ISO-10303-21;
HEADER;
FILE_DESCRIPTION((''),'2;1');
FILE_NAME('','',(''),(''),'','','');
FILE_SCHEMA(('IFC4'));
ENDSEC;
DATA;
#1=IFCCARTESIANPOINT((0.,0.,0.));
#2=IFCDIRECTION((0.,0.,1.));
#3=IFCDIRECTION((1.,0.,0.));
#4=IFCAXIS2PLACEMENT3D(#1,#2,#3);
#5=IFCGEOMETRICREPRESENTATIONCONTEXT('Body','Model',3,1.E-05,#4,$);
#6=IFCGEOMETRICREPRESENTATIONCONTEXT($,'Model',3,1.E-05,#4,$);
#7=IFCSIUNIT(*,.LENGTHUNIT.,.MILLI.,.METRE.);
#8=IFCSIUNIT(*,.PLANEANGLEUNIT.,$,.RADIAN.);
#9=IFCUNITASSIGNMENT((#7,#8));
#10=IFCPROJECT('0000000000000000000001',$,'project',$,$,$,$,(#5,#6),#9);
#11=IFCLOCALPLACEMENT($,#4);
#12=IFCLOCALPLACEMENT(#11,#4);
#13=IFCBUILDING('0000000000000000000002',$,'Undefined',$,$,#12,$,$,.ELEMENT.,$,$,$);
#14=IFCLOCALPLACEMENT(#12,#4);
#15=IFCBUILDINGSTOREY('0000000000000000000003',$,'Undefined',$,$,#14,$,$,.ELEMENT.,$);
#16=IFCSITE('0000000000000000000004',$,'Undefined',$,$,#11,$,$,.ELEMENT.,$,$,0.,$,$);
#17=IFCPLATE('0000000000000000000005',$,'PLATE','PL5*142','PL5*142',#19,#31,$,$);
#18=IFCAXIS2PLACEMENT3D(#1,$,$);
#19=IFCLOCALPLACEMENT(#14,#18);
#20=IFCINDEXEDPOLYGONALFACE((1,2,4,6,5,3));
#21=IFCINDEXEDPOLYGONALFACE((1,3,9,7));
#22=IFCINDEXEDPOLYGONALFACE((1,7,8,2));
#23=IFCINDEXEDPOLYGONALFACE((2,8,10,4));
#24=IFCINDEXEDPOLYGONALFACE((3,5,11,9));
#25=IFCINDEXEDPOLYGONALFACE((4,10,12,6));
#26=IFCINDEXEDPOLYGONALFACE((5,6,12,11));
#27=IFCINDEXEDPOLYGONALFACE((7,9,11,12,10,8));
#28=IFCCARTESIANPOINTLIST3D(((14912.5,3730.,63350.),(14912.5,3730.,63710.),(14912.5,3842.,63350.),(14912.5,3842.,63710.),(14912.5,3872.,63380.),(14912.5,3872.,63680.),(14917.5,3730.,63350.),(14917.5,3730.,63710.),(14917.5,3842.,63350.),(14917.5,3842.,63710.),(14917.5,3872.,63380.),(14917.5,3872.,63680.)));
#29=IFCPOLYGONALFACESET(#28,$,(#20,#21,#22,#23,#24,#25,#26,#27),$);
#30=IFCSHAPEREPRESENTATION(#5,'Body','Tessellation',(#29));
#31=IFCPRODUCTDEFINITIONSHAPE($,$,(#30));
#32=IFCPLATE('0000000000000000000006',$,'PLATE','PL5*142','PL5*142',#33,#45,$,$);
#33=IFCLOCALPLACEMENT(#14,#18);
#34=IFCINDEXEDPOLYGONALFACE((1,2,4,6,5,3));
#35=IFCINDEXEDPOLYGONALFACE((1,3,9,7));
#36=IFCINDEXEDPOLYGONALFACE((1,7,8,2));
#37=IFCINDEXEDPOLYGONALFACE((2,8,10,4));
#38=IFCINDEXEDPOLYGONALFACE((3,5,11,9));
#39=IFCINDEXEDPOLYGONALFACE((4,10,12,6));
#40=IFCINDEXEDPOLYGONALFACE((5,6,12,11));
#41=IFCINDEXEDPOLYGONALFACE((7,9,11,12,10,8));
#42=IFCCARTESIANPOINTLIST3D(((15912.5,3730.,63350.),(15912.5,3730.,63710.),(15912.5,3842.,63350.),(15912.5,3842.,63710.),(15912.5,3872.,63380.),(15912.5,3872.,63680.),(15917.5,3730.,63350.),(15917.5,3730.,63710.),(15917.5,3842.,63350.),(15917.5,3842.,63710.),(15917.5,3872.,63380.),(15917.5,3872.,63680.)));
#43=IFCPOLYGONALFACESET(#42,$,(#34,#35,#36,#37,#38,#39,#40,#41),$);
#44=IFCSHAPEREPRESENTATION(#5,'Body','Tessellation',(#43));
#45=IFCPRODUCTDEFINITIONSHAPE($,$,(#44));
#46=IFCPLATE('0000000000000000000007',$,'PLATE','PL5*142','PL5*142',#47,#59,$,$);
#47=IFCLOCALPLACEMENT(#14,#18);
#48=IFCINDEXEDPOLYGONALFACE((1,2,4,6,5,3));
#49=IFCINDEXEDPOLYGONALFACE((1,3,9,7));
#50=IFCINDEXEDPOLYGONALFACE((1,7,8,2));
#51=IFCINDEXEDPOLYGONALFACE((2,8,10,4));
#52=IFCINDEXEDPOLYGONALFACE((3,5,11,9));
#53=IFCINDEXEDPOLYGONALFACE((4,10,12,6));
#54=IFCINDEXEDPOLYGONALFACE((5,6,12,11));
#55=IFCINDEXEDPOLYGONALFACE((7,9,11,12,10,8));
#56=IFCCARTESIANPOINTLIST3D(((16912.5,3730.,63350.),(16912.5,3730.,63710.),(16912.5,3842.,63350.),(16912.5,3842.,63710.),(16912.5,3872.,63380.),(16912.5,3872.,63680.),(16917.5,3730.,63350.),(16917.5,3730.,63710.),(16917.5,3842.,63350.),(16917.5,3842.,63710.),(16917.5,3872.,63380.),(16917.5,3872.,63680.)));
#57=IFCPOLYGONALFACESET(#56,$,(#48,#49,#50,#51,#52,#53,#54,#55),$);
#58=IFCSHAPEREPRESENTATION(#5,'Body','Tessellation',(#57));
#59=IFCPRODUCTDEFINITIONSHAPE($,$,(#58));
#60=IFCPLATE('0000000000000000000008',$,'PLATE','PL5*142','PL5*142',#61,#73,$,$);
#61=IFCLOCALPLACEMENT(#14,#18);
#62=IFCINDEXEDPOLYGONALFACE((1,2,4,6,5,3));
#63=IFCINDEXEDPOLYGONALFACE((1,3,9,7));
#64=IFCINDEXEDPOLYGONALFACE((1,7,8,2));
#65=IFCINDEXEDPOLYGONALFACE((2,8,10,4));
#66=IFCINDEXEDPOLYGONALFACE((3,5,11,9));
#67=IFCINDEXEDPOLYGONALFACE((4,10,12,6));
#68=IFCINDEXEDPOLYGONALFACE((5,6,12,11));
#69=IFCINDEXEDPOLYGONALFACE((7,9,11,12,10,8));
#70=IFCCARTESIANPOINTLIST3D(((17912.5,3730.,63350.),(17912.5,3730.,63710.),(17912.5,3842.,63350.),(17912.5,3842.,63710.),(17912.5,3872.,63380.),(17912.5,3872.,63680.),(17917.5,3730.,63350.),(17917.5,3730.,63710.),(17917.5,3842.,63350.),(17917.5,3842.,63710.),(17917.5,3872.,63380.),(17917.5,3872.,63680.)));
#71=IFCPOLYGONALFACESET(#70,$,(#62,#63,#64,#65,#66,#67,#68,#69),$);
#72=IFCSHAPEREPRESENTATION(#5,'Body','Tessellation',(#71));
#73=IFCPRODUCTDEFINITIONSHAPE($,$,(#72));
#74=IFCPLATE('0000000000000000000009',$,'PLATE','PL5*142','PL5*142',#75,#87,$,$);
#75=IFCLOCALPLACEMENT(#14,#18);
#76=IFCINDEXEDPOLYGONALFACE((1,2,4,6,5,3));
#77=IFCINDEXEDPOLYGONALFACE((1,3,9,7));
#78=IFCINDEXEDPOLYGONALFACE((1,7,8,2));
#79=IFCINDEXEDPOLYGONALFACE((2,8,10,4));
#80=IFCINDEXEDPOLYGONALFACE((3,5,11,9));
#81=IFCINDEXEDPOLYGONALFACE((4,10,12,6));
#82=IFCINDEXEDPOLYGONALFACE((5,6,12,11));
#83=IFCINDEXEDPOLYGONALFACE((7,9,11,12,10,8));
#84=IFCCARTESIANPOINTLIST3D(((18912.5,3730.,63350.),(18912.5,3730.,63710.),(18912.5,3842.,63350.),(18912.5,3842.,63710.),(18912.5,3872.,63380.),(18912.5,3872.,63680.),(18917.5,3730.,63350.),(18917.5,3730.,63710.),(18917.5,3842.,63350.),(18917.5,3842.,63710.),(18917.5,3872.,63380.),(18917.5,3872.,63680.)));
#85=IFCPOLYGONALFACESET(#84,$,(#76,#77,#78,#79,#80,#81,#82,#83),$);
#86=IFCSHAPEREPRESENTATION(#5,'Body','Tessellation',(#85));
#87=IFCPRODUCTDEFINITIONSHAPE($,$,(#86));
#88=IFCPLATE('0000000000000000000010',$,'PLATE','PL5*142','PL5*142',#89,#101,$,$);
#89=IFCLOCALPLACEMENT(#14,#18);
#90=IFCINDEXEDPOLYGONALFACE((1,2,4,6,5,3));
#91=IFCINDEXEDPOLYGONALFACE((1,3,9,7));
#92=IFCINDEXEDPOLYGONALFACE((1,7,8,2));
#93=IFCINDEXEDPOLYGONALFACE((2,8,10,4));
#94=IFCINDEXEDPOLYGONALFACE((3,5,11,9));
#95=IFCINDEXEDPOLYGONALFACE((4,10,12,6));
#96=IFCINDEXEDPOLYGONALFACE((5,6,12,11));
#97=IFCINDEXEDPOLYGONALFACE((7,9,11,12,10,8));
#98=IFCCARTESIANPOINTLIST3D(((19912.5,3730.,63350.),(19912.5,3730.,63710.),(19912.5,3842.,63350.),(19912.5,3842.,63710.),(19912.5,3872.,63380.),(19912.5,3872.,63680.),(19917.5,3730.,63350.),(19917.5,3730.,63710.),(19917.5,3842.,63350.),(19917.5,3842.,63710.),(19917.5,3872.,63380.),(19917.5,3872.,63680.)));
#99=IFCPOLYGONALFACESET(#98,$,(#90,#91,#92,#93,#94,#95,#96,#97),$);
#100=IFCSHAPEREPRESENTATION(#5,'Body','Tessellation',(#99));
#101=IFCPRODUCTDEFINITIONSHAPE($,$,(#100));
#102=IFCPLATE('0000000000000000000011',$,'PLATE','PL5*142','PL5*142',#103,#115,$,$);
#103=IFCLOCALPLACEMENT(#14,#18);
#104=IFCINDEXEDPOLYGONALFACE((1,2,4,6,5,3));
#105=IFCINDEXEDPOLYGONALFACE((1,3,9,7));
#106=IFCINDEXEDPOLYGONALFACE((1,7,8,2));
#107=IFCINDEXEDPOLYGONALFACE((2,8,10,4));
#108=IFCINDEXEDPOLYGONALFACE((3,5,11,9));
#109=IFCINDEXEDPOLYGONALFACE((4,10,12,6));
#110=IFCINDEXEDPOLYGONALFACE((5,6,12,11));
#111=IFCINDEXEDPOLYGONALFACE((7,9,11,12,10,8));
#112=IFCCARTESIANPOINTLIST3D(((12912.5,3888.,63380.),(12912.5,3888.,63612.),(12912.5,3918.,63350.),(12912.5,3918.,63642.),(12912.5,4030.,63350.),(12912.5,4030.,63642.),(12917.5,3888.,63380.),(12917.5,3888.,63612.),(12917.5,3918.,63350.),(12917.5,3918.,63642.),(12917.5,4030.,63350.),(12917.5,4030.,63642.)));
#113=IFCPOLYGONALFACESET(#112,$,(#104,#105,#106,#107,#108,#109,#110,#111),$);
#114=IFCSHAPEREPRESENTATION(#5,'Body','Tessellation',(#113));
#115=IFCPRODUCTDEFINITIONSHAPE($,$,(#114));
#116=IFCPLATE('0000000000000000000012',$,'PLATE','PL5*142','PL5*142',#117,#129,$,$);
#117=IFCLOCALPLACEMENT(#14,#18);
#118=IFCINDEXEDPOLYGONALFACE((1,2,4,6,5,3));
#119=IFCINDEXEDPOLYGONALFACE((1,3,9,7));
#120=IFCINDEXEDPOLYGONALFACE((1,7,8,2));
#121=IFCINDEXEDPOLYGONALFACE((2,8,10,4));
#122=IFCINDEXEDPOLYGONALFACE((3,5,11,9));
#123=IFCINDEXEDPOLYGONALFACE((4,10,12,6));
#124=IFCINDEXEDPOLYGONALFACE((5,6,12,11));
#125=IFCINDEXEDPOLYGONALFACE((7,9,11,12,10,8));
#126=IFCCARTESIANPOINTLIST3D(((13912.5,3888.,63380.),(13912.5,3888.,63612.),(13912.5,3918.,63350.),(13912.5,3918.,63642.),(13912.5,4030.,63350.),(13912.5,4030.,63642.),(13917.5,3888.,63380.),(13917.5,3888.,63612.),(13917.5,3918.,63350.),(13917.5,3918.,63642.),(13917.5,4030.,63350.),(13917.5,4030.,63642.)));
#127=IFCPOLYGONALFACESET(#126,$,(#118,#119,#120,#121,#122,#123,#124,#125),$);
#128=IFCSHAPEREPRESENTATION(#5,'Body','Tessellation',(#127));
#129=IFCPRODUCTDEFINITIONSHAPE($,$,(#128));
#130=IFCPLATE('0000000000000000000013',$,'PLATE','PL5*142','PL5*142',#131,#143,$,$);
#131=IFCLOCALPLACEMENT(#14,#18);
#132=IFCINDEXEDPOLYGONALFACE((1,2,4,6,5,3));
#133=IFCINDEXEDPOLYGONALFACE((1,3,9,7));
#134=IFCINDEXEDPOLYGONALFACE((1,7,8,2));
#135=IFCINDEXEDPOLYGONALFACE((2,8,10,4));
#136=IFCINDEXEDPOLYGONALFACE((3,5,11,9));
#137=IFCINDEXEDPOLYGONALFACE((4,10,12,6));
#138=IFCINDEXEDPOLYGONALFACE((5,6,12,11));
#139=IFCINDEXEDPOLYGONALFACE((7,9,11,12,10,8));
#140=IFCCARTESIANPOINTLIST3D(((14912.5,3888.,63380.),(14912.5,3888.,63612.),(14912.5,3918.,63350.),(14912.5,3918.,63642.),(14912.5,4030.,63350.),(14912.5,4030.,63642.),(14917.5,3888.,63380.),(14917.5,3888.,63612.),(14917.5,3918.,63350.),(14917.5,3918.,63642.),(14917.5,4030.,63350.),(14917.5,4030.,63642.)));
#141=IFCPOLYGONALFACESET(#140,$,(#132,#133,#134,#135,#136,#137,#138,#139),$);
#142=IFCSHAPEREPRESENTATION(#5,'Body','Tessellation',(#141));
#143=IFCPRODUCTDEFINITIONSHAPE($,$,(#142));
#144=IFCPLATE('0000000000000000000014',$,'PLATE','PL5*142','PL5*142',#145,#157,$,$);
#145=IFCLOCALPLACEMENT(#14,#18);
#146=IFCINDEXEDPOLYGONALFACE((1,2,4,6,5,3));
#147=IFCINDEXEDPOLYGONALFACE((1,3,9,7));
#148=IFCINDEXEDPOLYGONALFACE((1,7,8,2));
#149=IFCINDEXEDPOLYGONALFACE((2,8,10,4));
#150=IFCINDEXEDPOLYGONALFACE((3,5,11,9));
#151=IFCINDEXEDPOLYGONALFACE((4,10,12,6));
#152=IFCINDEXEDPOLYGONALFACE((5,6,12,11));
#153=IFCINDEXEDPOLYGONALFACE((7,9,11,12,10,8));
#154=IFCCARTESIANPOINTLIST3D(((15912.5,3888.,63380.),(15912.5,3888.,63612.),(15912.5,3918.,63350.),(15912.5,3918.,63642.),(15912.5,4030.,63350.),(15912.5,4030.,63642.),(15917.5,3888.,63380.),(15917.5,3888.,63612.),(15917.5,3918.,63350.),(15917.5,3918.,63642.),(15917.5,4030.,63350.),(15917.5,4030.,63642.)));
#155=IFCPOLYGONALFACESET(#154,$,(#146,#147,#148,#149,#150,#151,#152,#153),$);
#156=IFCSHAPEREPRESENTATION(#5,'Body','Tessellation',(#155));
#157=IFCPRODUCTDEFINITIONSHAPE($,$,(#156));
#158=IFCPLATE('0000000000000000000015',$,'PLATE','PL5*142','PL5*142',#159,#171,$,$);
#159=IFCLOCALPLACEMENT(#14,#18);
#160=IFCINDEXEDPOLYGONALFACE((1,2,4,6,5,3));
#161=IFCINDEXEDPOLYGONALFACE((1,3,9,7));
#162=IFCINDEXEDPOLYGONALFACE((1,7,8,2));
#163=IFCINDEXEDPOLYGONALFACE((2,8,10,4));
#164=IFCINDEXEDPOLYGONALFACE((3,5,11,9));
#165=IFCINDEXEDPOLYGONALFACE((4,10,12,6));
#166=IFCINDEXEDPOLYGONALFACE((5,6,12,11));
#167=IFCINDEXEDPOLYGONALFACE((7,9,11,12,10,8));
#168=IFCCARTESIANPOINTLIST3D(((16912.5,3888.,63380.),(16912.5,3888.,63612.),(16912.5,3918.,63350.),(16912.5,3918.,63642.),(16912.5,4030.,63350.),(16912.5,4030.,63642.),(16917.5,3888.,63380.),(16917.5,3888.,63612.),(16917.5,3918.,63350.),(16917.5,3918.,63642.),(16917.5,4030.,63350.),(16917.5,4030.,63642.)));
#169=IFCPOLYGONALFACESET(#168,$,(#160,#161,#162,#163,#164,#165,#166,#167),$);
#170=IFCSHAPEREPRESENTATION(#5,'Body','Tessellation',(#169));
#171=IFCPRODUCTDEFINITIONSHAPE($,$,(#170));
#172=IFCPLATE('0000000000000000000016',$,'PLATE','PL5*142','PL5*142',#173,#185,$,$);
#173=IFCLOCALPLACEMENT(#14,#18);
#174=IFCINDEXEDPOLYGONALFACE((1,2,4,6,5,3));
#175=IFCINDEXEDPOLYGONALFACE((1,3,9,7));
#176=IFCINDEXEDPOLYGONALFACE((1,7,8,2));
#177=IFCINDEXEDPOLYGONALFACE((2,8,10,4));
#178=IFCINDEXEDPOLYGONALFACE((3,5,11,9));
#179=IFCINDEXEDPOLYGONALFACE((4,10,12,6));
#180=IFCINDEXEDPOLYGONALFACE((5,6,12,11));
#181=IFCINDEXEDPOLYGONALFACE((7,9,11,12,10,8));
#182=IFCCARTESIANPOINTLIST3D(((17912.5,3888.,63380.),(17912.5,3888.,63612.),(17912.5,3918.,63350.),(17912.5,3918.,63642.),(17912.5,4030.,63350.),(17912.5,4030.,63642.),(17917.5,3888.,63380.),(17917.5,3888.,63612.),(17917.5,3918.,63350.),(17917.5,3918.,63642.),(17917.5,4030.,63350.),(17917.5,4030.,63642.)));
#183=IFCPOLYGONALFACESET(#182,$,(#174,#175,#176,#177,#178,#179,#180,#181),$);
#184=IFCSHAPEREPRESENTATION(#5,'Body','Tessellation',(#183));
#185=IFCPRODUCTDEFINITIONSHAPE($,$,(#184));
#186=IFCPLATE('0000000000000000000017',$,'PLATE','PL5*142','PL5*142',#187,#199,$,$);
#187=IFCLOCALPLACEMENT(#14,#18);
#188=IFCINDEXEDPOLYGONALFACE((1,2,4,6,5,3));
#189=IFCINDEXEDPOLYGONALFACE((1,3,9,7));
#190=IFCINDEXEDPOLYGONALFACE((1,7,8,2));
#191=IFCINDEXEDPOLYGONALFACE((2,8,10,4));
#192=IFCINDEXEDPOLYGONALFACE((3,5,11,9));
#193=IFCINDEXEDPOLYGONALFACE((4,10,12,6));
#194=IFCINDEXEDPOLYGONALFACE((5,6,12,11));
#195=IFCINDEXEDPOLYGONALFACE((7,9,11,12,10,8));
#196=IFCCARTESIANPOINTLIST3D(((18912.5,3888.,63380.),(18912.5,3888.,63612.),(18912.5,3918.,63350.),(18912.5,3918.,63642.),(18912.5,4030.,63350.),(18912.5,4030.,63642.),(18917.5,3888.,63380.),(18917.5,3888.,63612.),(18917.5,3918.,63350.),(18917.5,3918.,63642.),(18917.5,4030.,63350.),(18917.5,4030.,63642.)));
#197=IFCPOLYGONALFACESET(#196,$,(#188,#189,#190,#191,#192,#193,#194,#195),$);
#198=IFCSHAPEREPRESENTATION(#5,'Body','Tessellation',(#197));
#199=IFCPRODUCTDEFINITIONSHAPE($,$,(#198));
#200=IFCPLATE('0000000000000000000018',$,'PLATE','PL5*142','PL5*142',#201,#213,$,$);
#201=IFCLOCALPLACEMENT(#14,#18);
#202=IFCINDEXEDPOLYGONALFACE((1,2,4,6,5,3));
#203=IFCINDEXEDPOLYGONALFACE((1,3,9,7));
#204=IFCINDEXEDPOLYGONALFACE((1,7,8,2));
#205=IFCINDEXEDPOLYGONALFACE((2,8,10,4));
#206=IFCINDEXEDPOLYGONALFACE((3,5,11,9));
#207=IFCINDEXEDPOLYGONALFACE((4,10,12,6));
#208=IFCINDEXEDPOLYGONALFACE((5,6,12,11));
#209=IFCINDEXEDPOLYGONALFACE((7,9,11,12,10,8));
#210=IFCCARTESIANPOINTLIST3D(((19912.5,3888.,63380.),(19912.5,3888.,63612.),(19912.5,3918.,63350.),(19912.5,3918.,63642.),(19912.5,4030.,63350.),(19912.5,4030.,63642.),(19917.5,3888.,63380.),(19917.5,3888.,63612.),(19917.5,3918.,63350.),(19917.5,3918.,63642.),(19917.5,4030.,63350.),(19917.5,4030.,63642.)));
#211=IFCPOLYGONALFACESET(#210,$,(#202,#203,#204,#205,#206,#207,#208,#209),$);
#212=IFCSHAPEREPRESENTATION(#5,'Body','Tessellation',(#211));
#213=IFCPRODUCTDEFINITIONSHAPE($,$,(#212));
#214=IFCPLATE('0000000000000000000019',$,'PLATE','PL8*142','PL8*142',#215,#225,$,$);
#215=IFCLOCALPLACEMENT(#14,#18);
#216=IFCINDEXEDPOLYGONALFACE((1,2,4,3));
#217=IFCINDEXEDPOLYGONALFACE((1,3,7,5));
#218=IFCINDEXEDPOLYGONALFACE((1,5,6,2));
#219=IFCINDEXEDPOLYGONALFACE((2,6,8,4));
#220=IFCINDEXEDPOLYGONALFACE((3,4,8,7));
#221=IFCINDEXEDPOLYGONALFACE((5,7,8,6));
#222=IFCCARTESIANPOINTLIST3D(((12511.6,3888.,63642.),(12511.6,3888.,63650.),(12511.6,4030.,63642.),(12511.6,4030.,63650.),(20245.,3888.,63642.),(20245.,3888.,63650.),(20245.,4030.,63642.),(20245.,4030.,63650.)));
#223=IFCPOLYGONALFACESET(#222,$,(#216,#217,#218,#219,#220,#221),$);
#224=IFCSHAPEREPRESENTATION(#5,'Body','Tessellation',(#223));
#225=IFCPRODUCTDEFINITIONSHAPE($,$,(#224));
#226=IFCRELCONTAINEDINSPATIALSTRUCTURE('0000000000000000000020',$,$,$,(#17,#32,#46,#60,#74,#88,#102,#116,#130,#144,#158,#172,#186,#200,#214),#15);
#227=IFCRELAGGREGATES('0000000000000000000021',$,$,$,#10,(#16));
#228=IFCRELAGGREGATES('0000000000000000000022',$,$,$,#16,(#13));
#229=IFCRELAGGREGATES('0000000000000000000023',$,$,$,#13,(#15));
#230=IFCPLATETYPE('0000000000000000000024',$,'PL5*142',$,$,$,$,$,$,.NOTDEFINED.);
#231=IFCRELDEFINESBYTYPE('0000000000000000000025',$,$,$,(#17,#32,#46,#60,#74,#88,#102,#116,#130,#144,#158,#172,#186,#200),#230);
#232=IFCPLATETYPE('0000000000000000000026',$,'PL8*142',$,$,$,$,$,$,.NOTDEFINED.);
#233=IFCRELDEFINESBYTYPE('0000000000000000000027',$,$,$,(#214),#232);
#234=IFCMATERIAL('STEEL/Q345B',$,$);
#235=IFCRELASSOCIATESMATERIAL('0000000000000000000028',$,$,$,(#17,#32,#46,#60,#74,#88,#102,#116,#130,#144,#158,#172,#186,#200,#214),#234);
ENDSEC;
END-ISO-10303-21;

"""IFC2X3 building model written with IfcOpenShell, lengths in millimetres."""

from ifc_helpers import new_model, si_unit, frame, origin_with_axes, place, context, project, spatial, polyline, outline, extrude, material, type_object, element, save


model = new_model("IFC2X3")

# Units and contexts
model_context_1 = context("Model", 3, precision=1e-05, world=origin_with_axes(), identifier="Body")
model_context_2 = context("Model", 3, precision=1e-05, world=origin_with_axes())
ifc_project = project(units=[si_unit("LENGTHUNIT", "METRE", prefix="MILLI"), si_unit("PLANEANGLEUNIT", "RADIAN")], contexts=[model_context_1, model_context_2])

# Site, building, storey
site_placement = place(None, origin_with_axes())
site = spatial("IfcSite", under=ifc_project, at=site_placement, Name="Undefined", CompositionType="ELEMENT", RefElevation=0.0)
building_placement = place(site_placement, origin_with_axes())
building = spatial("IfcBuilding", under=site, at=building_placement, Name="Undefined", CompositionType="ELEMENT")
storey_placement = place(building_placement, origin_with_axes())
storey = spatial("IfcBuildingStorey", under=building, at=storey_placement, Name="Undefined", CompositionType="ELEMENT")

# Shared definitions
ifc_material_1 = material(Name="STEEL/Q345B")

# Plates
plate_type_1 = type_object("IfcPlateType", Name="PL5*142", PredefinedType="NOTDEFINED")
for number, where, z_axis, x_axis, name in (
    (1, (14915.0, 3730.0, 63710.0), (-1.0, 0.0, 0.0), (0.0, 1.0, 0.0), "PLATE"),
    (2, (15915.0, 3730.0, 63710.0), (-1.0, 0.0, 0.0), (0.0, 1.0, 0.0), "PLATE"),
    (3, (16915.0, 3730.0, 63710.0), (-1.0, 0.0, 0.0), (0.0, 1.0, 0.0), "PLATE"),
    (4, (17915.0, 3730.0, 63710.0), (-1.0, 0.0, 0.0), (0.0, 1.0, 0.0), "PLATE"),
    (5, (18915.0, 3730.0, 63710.0), (-1.0, 0.0, 0.0), (0.0, 1.0, 0.0), "PLATE"),
    (6, (19915.0, 3730.0, 63710.0), (-1.0, 0.0, 0.0), (0.0, 1.0, 0.0), "PLATE"),
):
    element("IfcPlate", number, at=place(storey_placement, frame(where, z_axis=z_axis, x_axis=x_axis)), inside=storey, type_object=plate_type_1, material=ifc_material_1, Name=name, Description="PL5*142", ObjectType="PL5*142", context=model_context_1, shape_type="SweptSolid", body=[
        extrude(outline(polyline([(0.0, 0.0), (112.0, 0.0), (142.0, 30.0), (142.0, 330.0), (112.0, 360.0), (0.0, 360.0), (0.0, 0.0)])), frame((0.0, 0.0, -2.5), z_axis=(0.0, 0.0, 1.0), x_axis=(1.0, 0.0, 0.0)), (0.0, 0.0, 1.0), 5.0),
    ])
for number, where, z_axis, x_axis, name in (
    (7, (12915.0, 4030.0, 63642.0), (1.0, 0.0, 0.0), (0.0, -1.0, 0.0), "PLATE"),
    (8, (13915.0, 4030.0, 63642.0), (1.0, 0.0, 0.0), (0.0, -1.0, 0.0), "PLATE"),
    (9, (14915.0, 4030.0, 63642.0), (1.0, 0.0, 0.0), (0.0, -1.0, 0.0), "PLATE"),
    (10, (15915.0, 4030.0, 63642.0), (1.0, 0.0, 0.0), (0.0, -1.0, 0.0), "PLATE"),
    (11, (16915.0, 4030.0, 63642.0), (1.0, 0.0, 0.0), (0.0, -1.0, 0.0), "PLATE"),
    (12, (17915.0, 4030.0, 63642.0), (1.0, 0.0, 0.0), (0.0, -1.0, 0.0), "PLATE"),
    (13, (18915.0, 4030.0, 63642.0), (1.0, 0.0, 0.0), (0.0, -1.0, 0.0), "PLATE"),
    (14, (19915.0, 4030.0, 63642.0), (1.0, 0.0, 0.0), (0.0, -1.0, 0.0), "PLATE"),
):
    element("IfcPlate", number, at=place(storey_placement, frame(where, z_axis=z_axis, x_axis=x_axis)), inside=storey, type_object=plate_type_1, material=ifc_material_1, Name=name, Description="PL5*142", ObjectType="PL5*142", context=model_context_1, shape_type="SweptSolid", body=[
        extrude(outline(polyline([(0.0, 0.0), (112.0, 0.0), (142.0, 30.0), (142.0, 262.0), (112.0, 292.0), (0.0, 292.0), (0.0, 0.0)])), frame((0.0, 0.0, -2.5), z_axis=(0.0, 0.0, 1.0), x_axis=(1.0, 0.0, 0.0)), (0.0, 0.0, 1.0), 5.0),
    ])
plate_type_2 = type_object("IfcPlateType", Name="PL8*142", PredefinedType="NOTDEFINED")
plate_1_placement = place(storey_placement, frame((20245.0, 4030.0, 63646.0), z_axis=(0.0, 0.0, 1.0), x_axis=(-1.0, 0.0, 0.0)))
element("IfcPlate", 15, at=plate_1_placement, inside=storey, type_object=plate_type_2, material=ifc_material_1, Name="PLATE", Description="PL8*142", ObjectType="PL8*142", context=model_context_1, shape_type="SweptSolid", body=[
    extrude(outline(polyline([(0.0, 0.0), (7733.4, 0.0), (7733.4, 142.0), (0.0, 142.0), (0.0, 0.0)])), frame((0.0, 0.0, -4.0), z_axis=(0.0, 0.0, 1.0), x_axis=(1.0, 0.0, 0.0)), (0.0, 0.0, 1.0), 8.0),
])

save(model, "model.ifc")
